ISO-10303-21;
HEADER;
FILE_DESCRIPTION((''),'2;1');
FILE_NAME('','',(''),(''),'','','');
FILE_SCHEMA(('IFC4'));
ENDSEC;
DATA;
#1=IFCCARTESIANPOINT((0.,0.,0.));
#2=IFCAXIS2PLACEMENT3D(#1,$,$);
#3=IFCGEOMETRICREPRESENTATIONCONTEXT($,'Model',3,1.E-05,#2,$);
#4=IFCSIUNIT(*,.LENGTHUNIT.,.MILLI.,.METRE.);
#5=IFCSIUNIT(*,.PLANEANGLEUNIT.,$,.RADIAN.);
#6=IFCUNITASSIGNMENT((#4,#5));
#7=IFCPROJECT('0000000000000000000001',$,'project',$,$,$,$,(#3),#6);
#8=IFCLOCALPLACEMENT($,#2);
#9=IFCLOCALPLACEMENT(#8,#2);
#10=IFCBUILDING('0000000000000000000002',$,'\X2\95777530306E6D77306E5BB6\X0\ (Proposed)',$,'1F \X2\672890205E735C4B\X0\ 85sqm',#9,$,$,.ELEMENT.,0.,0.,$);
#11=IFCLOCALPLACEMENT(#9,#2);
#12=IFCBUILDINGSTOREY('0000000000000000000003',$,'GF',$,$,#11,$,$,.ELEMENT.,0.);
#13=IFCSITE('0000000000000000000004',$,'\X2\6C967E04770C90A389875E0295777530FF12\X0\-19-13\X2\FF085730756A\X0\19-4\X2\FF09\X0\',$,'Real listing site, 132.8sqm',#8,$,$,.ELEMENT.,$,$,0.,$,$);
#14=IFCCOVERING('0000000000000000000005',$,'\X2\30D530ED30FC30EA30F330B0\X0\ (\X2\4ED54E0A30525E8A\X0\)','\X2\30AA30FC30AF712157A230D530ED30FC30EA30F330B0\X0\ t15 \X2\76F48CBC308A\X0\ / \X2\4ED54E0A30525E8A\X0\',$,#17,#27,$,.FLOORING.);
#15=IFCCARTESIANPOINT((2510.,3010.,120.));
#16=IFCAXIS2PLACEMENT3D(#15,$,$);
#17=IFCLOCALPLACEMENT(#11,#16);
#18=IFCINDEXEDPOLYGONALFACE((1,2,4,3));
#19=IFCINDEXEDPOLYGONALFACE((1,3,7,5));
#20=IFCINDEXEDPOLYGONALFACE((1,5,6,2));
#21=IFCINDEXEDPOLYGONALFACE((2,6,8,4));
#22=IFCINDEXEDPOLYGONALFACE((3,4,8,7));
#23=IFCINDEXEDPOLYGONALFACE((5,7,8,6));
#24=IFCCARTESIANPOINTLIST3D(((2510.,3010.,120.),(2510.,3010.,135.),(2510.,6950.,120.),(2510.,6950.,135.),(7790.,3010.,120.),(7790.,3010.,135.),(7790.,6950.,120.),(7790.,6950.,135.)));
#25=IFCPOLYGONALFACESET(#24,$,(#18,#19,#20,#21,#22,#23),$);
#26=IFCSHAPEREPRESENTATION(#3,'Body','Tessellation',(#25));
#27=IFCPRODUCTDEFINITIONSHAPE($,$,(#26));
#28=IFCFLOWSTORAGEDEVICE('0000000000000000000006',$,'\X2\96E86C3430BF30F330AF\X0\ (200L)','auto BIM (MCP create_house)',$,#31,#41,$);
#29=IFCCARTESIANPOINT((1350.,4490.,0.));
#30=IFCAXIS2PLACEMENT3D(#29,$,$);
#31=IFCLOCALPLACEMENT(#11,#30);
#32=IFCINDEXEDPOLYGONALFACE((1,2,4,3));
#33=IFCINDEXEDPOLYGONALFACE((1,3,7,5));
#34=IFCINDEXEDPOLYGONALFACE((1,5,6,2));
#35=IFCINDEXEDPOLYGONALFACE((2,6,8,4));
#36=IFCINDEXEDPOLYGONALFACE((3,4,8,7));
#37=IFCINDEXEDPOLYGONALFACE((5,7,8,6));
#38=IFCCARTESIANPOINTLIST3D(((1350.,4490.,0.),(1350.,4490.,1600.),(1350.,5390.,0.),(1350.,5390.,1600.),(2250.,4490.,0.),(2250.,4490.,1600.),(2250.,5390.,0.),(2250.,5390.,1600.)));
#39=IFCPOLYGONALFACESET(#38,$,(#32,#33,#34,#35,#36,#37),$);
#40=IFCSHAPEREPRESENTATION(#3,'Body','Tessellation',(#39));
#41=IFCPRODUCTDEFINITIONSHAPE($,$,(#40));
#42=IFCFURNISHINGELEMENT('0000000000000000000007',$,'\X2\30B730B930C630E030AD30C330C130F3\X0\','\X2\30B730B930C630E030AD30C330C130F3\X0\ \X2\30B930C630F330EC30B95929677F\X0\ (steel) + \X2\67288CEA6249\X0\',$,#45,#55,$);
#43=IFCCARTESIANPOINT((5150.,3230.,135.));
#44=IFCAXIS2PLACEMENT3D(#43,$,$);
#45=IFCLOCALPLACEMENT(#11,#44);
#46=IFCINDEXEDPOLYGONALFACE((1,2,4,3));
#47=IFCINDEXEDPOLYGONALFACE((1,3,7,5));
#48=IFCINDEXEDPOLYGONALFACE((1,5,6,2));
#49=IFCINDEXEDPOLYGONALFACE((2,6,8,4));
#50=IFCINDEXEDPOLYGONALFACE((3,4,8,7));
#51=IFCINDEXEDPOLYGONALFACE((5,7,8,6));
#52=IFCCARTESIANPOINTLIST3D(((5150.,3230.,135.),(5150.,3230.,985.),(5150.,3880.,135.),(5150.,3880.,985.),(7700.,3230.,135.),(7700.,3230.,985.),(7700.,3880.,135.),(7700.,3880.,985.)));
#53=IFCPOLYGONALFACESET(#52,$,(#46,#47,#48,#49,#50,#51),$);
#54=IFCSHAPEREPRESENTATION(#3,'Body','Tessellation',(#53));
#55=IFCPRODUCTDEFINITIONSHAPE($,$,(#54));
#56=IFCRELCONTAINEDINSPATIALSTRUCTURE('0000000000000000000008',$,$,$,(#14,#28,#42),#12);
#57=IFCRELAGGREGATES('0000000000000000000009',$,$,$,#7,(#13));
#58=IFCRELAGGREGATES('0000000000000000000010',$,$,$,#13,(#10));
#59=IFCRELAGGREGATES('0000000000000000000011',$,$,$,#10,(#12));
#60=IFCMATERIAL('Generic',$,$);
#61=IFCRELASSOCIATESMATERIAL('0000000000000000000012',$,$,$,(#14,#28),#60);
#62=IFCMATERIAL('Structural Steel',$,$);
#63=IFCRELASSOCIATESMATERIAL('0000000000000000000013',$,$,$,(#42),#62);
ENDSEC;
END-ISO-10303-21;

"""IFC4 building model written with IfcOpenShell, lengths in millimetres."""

from ifc_helpers import new_model, si_unit, frame, frame_2d, origin, place, context, project, spatial, rectangle, extrude, material, element, save


model = new_model("IFC4")

# Units and contexts
model_context = context("Model", 3, precision=1e-05, world=origin())
ifc_project = project(units=[si_unit("LENGTHUNIT", "METRE", prefix="MILLI"), si_unit("PLANEANGLEUNIT", "RADIAN")], contexts=[model_context])

# Site, building, storey
site_placement = place(None, origin())
site = spatial("IfcSite", under=ifc_project, at=site_placement, Name="沖縄県那覇市長田２-19-13（地番19-4）", ObjectType="Real listing site, 132.8sqm", CompositionType="ELEMENT", RefElevation=0.0)
building_placement = place(site_placement, origin())
building = spatial("IfcBuilding", under=site, at=building_placement, Name="長田の海の家 (Proposed)", ObjectType="1F 木造平屋 85sqm", CompositionType="ELEMENT", ElevationOfRefHeight=0.0, ElevationOfTerrain=0.0)
storey_placement = place(building_placement, origin())
storey = spatial("IfcBuildingStorey", under=building, at=storey_placement, Name="GF", CompositionType="ELEMENT", Elevation=0.0)

# Shared definitions
ifc_material_1 = material(Name="Generic")

# Covering
covering_placement = place(storey_placement, frame((2510.0, 3010.0, 120.0)))
element("IfcCovering", 1, at=covering_placement, inside=storey, material=ifc_material_1, Name="フローリング (仕上げ床)", Description="オーク無垢フローリング t15 直貼り / 仕上げ床", PredefinedType="FLOORING", context=model_context, shape_type="SweptSolid", body=[
    extrude(rectangle(XDim=5280.0, YDim=3940.0, at=frame_2d((2640.0, 1970.0))), frame((2510.0, 3010.0, 120.0)), (0.0, 0.0, 1.0), 15.0),
])

# Flow storage device
flow_storage_device_placement = place(storey_placement, frame((1350.0, 4490.0, 0.0)))
element("IfcFlowStorageDevice", 2, at=flow_storage_device_placement, inside=storey, material=ifc_material_1, Name="雨水タンク (200L)", Description="auto BIM (MCP create_house)", context=model_context, shape_type="SweptSolid", body=[
    extrude(rectangle(XDim=900.0, YDim=900.0, at=frame_2d((450.0, 450.0))), frame((1350.0, 4490.0, 0.0)), (0.0, 0.0, 1.0), 1600.0),
])

# Furnishing element
ifc_material_2 = material(Name="Structural Steel")
furnishing_placement = place(storey_placement, frame((5150.0, 3230.0, 135.0)))
element("IfcFurnishingElement", 3, at=furnishing_placement, inside=storey, material=ifc_material_2, Name="システムキッチン", Description="システムキッチン ステンレス天板 (steel) + 木質扉", context=model_context, shape_type="SweptSolid", body=[
    extrude(rectangle(XDim=2550.0, YDim=650.0, at=frame_2d((1275.0, 325.0))), frame((5150.0, 3230.0, 135.0)), (0.0, 0.0, 1.0), 850.0),
])

save(model, "model.ifc")
